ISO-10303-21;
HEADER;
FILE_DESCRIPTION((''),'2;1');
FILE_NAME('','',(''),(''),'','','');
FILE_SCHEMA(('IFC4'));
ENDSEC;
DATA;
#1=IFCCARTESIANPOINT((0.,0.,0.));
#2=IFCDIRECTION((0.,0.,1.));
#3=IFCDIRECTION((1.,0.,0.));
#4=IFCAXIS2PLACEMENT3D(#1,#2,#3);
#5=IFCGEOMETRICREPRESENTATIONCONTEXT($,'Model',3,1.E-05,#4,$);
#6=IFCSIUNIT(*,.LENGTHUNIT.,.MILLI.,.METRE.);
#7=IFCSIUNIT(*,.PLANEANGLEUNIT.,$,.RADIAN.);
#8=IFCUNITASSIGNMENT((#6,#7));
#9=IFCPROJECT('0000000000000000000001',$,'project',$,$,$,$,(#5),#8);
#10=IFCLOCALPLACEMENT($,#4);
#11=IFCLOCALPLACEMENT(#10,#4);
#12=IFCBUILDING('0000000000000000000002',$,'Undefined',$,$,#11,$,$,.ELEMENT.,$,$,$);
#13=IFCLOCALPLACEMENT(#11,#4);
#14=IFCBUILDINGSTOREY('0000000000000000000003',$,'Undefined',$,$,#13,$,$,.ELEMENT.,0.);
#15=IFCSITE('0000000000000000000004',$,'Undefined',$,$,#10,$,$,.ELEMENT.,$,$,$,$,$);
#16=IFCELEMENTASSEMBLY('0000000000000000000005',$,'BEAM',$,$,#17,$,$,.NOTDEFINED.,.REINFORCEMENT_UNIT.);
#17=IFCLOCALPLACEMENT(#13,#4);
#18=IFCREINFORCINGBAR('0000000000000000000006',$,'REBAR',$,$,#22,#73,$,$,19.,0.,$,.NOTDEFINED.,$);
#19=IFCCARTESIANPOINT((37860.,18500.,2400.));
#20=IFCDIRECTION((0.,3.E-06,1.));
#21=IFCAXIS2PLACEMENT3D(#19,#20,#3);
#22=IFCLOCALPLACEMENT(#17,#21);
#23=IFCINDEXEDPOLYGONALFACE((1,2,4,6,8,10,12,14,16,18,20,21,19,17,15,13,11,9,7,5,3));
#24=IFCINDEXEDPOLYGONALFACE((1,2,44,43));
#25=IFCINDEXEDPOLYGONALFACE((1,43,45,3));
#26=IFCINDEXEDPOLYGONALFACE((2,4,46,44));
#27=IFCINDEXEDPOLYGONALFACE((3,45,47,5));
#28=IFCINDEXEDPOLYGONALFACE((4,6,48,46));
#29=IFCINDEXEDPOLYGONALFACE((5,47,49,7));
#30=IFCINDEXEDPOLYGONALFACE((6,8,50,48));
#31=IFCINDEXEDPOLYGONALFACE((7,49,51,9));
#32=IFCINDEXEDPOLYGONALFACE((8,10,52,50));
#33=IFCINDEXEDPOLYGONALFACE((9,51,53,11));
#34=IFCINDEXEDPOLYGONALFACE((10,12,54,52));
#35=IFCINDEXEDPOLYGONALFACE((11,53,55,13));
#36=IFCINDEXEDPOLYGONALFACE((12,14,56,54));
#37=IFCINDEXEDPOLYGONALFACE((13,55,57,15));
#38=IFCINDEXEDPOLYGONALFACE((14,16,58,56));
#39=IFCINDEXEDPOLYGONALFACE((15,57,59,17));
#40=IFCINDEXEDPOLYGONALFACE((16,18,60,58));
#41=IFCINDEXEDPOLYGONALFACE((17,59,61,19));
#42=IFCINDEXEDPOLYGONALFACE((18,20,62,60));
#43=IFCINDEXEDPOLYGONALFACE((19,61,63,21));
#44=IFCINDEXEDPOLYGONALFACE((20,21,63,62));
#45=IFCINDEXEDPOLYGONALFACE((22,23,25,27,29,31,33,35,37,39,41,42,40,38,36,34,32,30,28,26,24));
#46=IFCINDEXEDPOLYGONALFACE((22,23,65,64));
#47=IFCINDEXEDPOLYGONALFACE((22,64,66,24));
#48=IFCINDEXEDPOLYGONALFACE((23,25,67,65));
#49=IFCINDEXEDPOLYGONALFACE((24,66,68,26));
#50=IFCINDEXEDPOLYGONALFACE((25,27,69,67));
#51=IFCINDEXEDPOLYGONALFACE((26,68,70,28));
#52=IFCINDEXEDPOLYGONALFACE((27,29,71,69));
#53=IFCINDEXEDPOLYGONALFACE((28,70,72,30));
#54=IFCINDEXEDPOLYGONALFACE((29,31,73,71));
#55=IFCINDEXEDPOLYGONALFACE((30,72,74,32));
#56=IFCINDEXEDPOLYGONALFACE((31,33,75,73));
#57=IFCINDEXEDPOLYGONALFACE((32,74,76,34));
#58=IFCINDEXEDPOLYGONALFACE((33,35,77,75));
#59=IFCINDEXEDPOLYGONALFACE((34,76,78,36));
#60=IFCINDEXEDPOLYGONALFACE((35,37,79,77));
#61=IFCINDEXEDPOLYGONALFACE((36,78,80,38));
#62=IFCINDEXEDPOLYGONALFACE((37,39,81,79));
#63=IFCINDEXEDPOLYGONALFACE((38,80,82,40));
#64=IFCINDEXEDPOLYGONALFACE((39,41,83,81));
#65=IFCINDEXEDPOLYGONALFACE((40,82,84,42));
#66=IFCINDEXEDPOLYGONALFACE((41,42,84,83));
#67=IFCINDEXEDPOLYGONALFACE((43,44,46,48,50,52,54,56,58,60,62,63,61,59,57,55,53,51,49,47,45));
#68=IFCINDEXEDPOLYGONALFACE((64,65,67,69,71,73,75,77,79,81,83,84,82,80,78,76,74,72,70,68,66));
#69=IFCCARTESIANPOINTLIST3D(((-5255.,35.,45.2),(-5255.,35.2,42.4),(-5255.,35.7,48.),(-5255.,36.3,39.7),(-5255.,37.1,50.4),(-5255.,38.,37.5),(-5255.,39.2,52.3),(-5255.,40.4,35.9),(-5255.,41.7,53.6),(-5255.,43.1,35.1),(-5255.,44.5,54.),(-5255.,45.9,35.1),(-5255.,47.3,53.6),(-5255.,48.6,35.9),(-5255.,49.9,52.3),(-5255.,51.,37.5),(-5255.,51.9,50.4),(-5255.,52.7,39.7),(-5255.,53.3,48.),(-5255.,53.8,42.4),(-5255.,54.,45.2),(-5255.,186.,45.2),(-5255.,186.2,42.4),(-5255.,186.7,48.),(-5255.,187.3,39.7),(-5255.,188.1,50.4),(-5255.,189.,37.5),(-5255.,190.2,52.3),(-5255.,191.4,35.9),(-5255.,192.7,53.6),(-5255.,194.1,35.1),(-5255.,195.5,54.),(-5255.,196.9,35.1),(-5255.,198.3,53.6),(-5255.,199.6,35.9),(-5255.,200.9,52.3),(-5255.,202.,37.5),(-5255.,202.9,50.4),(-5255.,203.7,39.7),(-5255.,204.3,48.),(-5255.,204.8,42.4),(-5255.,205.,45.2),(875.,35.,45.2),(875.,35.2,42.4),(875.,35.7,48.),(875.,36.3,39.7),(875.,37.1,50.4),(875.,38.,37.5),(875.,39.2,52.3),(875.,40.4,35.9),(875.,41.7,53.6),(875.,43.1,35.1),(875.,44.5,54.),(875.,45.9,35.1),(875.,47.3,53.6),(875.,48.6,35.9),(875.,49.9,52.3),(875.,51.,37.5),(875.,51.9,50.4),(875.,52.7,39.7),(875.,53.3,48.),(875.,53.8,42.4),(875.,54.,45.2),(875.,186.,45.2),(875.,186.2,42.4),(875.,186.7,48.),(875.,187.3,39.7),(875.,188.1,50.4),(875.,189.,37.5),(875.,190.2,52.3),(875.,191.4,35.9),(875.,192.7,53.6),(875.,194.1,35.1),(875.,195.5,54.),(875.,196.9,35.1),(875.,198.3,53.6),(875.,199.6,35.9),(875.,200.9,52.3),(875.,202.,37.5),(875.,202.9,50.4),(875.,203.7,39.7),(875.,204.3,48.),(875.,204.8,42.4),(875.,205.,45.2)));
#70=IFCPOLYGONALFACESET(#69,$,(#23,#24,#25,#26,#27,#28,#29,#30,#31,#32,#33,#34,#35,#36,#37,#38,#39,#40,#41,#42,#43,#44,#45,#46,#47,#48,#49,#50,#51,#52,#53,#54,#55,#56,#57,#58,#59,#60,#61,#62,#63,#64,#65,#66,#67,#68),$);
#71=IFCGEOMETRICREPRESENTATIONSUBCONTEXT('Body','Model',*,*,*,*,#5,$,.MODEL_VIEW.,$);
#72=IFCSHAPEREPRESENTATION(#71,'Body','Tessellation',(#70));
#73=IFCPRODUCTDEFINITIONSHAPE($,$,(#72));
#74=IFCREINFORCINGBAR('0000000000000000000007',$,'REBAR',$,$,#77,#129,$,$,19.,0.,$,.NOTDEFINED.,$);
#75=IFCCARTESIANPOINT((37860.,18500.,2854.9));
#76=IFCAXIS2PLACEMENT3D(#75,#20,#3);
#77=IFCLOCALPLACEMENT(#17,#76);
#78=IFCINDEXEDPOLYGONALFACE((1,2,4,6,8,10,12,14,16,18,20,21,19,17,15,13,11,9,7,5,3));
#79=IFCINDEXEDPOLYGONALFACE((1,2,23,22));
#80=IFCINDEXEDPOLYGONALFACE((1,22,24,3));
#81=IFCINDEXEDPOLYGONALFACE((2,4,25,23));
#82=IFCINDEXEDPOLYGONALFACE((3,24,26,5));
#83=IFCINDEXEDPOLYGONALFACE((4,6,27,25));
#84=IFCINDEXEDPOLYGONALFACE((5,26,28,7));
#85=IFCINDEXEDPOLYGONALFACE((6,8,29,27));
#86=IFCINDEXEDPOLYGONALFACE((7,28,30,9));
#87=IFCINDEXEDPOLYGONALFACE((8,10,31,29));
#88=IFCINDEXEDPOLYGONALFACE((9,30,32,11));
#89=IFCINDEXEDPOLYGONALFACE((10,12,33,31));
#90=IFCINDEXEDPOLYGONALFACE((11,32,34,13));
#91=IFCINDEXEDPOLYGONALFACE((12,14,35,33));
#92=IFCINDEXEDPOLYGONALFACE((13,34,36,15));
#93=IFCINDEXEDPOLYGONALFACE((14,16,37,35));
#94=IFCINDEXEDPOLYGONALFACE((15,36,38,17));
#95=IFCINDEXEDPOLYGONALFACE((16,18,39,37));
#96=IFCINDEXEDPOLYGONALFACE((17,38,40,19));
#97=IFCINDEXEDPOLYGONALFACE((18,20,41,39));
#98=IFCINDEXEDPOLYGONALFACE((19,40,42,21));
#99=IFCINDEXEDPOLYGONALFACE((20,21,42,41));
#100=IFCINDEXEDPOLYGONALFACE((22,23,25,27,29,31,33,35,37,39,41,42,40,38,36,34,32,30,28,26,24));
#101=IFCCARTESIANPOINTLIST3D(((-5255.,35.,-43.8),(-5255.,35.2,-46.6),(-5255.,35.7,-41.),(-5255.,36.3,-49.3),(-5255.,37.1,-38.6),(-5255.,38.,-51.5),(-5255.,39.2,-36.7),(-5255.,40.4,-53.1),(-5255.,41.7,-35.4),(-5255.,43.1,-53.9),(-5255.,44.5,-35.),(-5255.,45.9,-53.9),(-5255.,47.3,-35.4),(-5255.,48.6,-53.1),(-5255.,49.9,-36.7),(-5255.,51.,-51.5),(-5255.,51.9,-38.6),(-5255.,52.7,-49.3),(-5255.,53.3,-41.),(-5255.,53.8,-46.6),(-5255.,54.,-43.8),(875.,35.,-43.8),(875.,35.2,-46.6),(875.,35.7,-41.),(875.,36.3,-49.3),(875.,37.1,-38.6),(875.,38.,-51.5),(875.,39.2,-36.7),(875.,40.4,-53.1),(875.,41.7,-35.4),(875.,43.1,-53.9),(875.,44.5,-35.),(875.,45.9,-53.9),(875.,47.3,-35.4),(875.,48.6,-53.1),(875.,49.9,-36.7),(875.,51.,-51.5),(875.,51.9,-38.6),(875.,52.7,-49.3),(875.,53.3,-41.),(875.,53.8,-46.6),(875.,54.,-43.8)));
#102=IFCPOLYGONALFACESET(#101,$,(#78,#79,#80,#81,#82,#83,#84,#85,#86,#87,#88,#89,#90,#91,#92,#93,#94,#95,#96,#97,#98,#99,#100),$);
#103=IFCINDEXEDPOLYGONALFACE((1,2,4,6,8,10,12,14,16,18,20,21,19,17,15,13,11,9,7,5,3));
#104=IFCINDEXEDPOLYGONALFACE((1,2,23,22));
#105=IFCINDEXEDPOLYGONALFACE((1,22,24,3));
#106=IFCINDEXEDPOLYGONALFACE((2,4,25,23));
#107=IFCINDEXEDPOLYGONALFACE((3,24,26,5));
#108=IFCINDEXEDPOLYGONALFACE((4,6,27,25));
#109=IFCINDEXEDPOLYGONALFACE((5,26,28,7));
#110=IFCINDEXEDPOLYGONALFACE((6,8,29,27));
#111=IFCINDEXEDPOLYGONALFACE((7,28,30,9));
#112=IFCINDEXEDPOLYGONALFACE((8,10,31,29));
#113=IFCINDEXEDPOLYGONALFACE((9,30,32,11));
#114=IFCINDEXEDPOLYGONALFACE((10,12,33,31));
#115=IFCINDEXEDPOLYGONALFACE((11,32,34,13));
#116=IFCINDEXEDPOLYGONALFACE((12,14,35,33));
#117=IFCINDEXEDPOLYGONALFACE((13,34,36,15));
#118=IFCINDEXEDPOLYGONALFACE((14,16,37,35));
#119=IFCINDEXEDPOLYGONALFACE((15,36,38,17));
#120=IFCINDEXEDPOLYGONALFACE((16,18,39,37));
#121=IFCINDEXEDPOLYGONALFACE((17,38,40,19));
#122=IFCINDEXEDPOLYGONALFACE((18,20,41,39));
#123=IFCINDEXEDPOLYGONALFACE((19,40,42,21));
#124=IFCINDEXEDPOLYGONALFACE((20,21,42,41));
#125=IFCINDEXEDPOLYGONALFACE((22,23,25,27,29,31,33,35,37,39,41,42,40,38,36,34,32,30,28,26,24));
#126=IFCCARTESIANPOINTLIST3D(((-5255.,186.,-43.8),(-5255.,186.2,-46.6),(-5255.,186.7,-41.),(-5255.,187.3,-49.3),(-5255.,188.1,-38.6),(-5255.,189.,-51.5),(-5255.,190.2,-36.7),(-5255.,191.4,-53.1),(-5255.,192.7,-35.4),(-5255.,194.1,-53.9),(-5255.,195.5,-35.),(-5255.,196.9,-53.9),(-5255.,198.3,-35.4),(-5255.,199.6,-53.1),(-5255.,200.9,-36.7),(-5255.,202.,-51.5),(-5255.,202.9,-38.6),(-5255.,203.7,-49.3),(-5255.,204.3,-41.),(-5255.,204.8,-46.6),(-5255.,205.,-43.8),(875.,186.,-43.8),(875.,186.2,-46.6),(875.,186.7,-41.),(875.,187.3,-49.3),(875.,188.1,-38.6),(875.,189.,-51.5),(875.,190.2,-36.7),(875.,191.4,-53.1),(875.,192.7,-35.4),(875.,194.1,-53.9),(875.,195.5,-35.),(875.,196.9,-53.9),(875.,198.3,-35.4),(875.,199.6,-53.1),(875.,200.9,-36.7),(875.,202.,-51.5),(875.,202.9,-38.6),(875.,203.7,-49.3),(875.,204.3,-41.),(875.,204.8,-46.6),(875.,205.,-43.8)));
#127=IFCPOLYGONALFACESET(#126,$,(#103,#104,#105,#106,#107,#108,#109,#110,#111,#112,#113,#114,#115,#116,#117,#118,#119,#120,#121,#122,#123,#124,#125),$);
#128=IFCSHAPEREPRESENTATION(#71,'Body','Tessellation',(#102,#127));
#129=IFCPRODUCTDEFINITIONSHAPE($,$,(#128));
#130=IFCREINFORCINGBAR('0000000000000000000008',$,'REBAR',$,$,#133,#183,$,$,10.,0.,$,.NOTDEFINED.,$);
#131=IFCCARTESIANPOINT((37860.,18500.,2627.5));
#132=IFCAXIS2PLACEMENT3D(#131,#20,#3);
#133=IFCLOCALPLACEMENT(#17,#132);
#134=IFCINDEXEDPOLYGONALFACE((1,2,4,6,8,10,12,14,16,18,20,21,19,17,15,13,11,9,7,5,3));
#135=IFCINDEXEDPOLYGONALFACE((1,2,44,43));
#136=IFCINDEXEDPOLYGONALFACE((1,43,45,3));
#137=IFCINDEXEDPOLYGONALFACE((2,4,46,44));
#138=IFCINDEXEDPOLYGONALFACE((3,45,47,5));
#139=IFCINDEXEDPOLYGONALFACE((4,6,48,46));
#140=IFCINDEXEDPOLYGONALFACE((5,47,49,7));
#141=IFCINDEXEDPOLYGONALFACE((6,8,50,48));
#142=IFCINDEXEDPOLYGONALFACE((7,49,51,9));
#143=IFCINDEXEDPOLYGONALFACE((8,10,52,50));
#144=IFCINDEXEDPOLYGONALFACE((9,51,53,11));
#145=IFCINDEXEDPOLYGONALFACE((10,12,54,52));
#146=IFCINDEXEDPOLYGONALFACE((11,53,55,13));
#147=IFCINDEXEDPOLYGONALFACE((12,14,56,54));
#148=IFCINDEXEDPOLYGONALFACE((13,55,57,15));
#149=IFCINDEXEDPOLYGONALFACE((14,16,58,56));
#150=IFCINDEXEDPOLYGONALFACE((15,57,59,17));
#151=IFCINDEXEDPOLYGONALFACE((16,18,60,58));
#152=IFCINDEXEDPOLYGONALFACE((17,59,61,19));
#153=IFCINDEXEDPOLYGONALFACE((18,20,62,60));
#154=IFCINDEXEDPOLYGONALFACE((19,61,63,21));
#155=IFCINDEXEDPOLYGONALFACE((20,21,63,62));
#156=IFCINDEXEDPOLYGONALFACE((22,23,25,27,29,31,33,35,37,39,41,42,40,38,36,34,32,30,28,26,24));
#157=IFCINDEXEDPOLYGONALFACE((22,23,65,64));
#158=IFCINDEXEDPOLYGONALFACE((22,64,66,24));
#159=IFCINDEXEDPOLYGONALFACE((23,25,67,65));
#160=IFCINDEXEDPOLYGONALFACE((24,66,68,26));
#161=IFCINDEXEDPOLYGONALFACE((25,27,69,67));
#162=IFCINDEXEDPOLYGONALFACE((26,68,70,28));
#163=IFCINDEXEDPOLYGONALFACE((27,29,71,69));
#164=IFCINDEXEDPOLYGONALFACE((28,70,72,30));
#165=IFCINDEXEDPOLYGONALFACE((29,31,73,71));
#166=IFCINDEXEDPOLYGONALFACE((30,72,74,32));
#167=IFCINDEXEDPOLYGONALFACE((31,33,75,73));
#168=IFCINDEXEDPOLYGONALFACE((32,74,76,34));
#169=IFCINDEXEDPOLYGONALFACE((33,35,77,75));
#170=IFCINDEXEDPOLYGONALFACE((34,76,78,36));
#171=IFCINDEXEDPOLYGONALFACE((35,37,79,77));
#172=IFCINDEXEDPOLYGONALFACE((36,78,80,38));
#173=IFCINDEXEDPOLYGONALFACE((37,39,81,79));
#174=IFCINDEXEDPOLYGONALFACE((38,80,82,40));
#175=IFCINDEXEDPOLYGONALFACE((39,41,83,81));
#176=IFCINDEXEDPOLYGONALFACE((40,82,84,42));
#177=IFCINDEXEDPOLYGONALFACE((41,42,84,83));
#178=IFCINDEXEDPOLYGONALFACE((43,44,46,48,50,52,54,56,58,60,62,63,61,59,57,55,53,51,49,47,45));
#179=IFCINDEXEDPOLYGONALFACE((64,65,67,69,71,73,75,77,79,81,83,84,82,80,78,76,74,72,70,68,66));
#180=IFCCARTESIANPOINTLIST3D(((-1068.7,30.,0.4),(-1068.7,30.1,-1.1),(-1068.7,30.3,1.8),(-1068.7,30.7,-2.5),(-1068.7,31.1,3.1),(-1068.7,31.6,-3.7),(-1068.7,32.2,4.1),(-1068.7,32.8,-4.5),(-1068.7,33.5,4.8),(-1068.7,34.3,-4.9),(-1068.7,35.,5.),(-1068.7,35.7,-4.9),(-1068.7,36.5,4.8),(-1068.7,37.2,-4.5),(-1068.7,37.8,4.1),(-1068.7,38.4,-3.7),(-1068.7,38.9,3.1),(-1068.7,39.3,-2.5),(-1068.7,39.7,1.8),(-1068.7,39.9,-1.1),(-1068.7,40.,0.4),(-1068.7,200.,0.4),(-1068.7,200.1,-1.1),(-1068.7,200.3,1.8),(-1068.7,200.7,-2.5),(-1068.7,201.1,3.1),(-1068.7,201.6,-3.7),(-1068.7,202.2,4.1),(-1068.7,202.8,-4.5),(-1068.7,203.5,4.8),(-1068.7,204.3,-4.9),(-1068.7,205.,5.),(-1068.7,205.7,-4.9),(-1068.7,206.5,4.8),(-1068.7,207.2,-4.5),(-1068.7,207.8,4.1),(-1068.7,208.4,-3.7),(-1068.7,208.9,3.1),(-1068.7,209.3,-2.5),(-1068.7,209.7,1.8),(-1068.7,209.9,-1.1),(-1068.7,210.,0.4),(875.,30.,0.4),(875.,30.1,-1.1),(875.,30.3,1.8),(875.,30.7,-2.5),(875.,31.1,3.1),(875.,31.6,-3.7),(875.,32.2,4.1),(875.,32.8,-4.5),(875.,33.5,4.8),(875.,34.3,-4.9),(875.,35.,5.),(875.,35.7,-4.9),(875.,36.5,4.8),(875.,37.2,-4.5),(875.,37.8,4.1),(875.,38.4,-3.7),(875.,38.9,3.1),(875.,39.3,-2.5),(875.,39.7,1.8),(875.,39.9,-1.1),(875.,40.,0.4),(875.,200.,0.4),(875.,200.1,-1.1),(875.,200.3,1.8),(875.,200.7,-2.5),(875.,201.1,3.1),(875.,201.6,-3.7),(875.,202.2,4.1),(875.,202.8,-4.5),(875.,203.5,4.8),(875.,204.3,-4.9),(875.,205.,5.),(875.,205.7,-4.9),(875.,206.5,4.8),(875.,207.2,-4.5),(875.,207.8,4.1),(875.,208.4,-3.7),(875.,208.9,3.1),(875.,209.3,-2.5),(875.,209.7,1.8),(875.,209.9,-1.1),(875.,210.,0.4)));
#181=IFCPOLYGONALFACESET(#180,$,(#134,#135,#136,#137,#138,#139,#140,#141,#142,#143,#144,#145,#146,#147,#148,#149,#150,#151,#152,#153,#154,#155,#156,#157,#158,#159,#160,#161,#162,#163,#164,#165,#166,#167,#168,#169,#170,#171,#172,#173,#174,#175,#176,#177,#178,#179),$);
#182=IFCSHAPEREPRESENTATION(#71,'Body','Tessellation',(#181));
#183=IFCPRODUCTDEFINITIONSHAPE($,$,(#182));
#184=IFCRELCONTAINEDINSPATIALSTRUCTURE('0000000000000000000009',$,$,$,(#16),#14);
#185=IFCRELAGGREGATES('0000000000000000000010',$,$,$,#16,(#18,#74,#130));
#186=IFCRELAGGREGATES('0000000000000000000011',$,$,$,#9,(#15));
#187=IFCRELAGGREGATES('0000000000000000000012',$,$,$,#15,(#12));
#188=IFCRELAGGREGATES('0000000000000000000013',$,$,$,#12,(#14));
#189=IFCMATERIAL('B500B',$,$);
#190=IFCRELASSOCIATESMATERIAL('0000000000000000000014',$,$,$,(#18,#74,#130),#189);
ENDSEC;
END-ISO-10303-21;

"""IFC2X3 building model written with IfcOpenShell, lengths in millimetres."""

from ifc_helpers import new_model, entity, si_unit, frame, origin_with_axes, place, context, subcontext, project, spatial, source, transform, mapped, material, element, aggregate, save


model = new_model("IFC2X3")

# Units and contexts
model_context = context("Model", 3, precision=1e-05, world=origin_with_axes())
body_context = subcontext(model_context, "Body", "Model", "MODEL_VIEW")
ifc_project = project(units=[si_unit("LENGTHUNIT", "METRE", prefix="MILLI"), si_unit("PLANEANGLEUNIT", "RADIAN")], contexts=[model_context])

# Site, building, storey
site_placement = place(None, origin_with_axes())
site = spatial("IfcSite", under=ifc_project, at=site_placement, Name="Undefined", CompositionType="ELEMENT")
building_placement = place(site_placement, origin_with_axes())
building = spatial("IfcBuilding", under=site, at=building_placement, Name="Undefined", CompositionType="ELEMENT")
storey_placement = place(building_placement, origin_with_axes())
storey = spatial("IfcBuildingStorey", under=building, at=storey_placement, Name="Undefined", CompositionType="ELEMENT", Elevation=0.0)

# Element assembly, reinforcing bars
assembly_1_placement = place(storey_placement, origin_with_axes())
assembly_1 = element("IfcElementAssembly", 1, at=assembly_1_placement, inside=storey, Name="BEAM", AssemblyPlace="NOTDEFINED", PredefinedType="REINFORCEMENT_UNIT")
ifc_material_1 = material(Name="B500B")
shared_shape_1 = source(origin_with_axes(), body_context, "Body", "AdvancedSweptSolid", [
    entity("IfcSweptDiskSolid", entity("IfcTrimmedCurve", entity("IfcLine", entity("IfcCartesianPoint", [0.0, 0.0, 0.0]), entity("IfcVector", entity("IfcDirection", [1.0, 0.0, 0.0]), 1.0)), [entity("IfcParameterValue", 0.0)], [entity("IfcParameterValue", 6129.992834)], True, "PARAMETER"), 9.5, None, 0.0, 6130.0),
])
shared_shape_2 = source(origin_with_axes(), body_context, "Body", "AdvancedSweptSolid", [
    entity("IfcSweptDiskSolid", entity("IfcTrimmedCurve", entity("IfcLine", entity("IfcCartesianPoint", [0.0, 0.0, 0.0]), entity("IfcVector", entity("IfcDirection", [1.0, 0.0, 0.0]), 1.0)), [entity("IfcParameterValue", 0.0)], [entity("IfcParameterValue", 6129.992834)], True, "PARAMETER"), 9.5, None, 0.0, 6130.0),
])
reinforcing_bar_1_placement = place(assembly_1_placement, frame((37860.0, 18500.0, 2400.0), z_axis=(0.0, 0.000003, 1.0), x_axis=(1.0, 0.0, 0.0)))
reinforcing_bar_1 = element("IfcReinforcingBar", 2, at=reinforcing_bar_1_placement, material=ifc_material_1, Name="REBAR", BarRole="NOTDEFINED", CrossSectionArea=0.0, NominalDiameter=19.0, context=body_context, shape_type="MappedRepresentation", body=[
    mapped(shared_shape_1, transform((-5255.0, 44.5, 44.5))),
    mapped(shared_shape_2, transform((-5255.0, 195.5, 44.5))),
])
shared_shape_3 = source(origin_with_axes(), body_context, "Body", "AdvancedSweptSolid", [
    entity("IfcSweptDiskSolid", entity("IfcTrimmedCurve", entity("IfcLine", entity("IfcCartesianPoint", [0.0, 0.0, 0.0]), entity("IfcVector", entity("IfcDirection", [1.0, 0.0, 0.0]), 1.0)), [entity("IfcParameterValue", 0.0)], [entity("IfcParameterValue", 6129.992834)], True, "PARAMETER"), 9.5, None, 0.0, 6130.0),
])
shared_shape_4 = source(origin_with_axes(), body_context, "Body", "AdvancedSweptSolid", [
    entity("IfcSweptDiskSolid", entity("IfcTrimmedCurve", entity("IfcLine", entity("IfcCartesianPoint", [0.0, 0.0, 0.0]), entity("IfcVector", entity("IfcDirection", [1.0, 0.0, 0.0]), 1.0)), [entity("IfcParameterValue", 0.0)], [entity("IfcParameterValue", 6129.992834)], True, "PARAMETER"), 9.5, None, 0.0, 6130.0),
])
reinforcing_bar_2_placement = place(assembly_1_placement, frame((37860.0, 18500.0, 2854.9), z_axis=(0.0, 0.000003, 1.0), x_axis=(1.0, 0.0, 0.0)))
reinforcing_bar_2 = element("IfcReinforcingBar", 3, at=reinforcing_bar_2_placement, material=ifc_material_1, Name="REBAR", BarRole="NOTDEFINED", CrossSectionArea=0.0, NominalDiameter=19.0, context=body_context, shape_type="MappedRepresentation", body=[
    mapped(shared_shape_3, transform((-5255.0, 44.5, -44.5))),
    mapped(shared_shape_4, transform((-5255.0, 195.5, -44.5))),
])
shared_shape_5 = source(origin_with_axes(), body_context, "Body", "AdvancedSweptSolid", [
    entity("IfcSweptDiskSolid", entity("IfcTrimmedCurve", entity("IfcLine", entity("IfcCartesianPoint", [0.0, 0.0, 0.0]), entity("IfcVector", entity("IfcDirection", [1.0, 0.0, 0.0]), 1.0)), [entity("IfcParameterValue", 0.0)], [entity("IfcParameterValue", 1943.692835)], True, "PARAMETER"), 5.0, None, 0.0, 1943.7),
])
shared_shape_6 = source(origin_with_axes(), body_context, "Body", "AdvancedSweptSolid", [
    entity("IfcSweptDiskSolid", entity("IfcTrimmedCurve", entity("IfcLine", entity("IfcCartesianPoint", [0.0, 0.0, 0.0]), entity("IfcVector", entity("IfcDirection", [1.0, 0.0, 0.0]), 1.0)), [entity("IfcParameterValue", 0.0)], [entity("IfcParameterValue", 1943.692835)], True, "PARAMETER"), 5.0, None, 0.0, 1943.7),
])
reinforcing_bar_3_placement = place(assembly_1_placement, frame((37860.0, 18500.0, 2627.5), z_axis=(0.0, 0.000003, 1.0), x_axis=(1.0, 0.0, 0.0)))
reinforcing_bar_3 = element("IfcReinforcingBar", 4, at=reinforcing_bar_3_placement, material=ifc_material_1, Name="REBAR", BarRole="NOTDEFINED", CrossSectionArea=0.0, NominalDiameter=10.0, context=body_context, shape_type="MappedRepresentation", body=[
    mapped(shared_shape_5, transform((-1068.7, 35.0, 0.0))),
    mapped(shared_shape_6, transform((-1068.7, 205.0, 0.0))),
])
aggregate(assembly_1, [reinforcing_bar_1, reinforcing_bar_2, reinforcing_bar_3])

save(model, "model.ifc")
